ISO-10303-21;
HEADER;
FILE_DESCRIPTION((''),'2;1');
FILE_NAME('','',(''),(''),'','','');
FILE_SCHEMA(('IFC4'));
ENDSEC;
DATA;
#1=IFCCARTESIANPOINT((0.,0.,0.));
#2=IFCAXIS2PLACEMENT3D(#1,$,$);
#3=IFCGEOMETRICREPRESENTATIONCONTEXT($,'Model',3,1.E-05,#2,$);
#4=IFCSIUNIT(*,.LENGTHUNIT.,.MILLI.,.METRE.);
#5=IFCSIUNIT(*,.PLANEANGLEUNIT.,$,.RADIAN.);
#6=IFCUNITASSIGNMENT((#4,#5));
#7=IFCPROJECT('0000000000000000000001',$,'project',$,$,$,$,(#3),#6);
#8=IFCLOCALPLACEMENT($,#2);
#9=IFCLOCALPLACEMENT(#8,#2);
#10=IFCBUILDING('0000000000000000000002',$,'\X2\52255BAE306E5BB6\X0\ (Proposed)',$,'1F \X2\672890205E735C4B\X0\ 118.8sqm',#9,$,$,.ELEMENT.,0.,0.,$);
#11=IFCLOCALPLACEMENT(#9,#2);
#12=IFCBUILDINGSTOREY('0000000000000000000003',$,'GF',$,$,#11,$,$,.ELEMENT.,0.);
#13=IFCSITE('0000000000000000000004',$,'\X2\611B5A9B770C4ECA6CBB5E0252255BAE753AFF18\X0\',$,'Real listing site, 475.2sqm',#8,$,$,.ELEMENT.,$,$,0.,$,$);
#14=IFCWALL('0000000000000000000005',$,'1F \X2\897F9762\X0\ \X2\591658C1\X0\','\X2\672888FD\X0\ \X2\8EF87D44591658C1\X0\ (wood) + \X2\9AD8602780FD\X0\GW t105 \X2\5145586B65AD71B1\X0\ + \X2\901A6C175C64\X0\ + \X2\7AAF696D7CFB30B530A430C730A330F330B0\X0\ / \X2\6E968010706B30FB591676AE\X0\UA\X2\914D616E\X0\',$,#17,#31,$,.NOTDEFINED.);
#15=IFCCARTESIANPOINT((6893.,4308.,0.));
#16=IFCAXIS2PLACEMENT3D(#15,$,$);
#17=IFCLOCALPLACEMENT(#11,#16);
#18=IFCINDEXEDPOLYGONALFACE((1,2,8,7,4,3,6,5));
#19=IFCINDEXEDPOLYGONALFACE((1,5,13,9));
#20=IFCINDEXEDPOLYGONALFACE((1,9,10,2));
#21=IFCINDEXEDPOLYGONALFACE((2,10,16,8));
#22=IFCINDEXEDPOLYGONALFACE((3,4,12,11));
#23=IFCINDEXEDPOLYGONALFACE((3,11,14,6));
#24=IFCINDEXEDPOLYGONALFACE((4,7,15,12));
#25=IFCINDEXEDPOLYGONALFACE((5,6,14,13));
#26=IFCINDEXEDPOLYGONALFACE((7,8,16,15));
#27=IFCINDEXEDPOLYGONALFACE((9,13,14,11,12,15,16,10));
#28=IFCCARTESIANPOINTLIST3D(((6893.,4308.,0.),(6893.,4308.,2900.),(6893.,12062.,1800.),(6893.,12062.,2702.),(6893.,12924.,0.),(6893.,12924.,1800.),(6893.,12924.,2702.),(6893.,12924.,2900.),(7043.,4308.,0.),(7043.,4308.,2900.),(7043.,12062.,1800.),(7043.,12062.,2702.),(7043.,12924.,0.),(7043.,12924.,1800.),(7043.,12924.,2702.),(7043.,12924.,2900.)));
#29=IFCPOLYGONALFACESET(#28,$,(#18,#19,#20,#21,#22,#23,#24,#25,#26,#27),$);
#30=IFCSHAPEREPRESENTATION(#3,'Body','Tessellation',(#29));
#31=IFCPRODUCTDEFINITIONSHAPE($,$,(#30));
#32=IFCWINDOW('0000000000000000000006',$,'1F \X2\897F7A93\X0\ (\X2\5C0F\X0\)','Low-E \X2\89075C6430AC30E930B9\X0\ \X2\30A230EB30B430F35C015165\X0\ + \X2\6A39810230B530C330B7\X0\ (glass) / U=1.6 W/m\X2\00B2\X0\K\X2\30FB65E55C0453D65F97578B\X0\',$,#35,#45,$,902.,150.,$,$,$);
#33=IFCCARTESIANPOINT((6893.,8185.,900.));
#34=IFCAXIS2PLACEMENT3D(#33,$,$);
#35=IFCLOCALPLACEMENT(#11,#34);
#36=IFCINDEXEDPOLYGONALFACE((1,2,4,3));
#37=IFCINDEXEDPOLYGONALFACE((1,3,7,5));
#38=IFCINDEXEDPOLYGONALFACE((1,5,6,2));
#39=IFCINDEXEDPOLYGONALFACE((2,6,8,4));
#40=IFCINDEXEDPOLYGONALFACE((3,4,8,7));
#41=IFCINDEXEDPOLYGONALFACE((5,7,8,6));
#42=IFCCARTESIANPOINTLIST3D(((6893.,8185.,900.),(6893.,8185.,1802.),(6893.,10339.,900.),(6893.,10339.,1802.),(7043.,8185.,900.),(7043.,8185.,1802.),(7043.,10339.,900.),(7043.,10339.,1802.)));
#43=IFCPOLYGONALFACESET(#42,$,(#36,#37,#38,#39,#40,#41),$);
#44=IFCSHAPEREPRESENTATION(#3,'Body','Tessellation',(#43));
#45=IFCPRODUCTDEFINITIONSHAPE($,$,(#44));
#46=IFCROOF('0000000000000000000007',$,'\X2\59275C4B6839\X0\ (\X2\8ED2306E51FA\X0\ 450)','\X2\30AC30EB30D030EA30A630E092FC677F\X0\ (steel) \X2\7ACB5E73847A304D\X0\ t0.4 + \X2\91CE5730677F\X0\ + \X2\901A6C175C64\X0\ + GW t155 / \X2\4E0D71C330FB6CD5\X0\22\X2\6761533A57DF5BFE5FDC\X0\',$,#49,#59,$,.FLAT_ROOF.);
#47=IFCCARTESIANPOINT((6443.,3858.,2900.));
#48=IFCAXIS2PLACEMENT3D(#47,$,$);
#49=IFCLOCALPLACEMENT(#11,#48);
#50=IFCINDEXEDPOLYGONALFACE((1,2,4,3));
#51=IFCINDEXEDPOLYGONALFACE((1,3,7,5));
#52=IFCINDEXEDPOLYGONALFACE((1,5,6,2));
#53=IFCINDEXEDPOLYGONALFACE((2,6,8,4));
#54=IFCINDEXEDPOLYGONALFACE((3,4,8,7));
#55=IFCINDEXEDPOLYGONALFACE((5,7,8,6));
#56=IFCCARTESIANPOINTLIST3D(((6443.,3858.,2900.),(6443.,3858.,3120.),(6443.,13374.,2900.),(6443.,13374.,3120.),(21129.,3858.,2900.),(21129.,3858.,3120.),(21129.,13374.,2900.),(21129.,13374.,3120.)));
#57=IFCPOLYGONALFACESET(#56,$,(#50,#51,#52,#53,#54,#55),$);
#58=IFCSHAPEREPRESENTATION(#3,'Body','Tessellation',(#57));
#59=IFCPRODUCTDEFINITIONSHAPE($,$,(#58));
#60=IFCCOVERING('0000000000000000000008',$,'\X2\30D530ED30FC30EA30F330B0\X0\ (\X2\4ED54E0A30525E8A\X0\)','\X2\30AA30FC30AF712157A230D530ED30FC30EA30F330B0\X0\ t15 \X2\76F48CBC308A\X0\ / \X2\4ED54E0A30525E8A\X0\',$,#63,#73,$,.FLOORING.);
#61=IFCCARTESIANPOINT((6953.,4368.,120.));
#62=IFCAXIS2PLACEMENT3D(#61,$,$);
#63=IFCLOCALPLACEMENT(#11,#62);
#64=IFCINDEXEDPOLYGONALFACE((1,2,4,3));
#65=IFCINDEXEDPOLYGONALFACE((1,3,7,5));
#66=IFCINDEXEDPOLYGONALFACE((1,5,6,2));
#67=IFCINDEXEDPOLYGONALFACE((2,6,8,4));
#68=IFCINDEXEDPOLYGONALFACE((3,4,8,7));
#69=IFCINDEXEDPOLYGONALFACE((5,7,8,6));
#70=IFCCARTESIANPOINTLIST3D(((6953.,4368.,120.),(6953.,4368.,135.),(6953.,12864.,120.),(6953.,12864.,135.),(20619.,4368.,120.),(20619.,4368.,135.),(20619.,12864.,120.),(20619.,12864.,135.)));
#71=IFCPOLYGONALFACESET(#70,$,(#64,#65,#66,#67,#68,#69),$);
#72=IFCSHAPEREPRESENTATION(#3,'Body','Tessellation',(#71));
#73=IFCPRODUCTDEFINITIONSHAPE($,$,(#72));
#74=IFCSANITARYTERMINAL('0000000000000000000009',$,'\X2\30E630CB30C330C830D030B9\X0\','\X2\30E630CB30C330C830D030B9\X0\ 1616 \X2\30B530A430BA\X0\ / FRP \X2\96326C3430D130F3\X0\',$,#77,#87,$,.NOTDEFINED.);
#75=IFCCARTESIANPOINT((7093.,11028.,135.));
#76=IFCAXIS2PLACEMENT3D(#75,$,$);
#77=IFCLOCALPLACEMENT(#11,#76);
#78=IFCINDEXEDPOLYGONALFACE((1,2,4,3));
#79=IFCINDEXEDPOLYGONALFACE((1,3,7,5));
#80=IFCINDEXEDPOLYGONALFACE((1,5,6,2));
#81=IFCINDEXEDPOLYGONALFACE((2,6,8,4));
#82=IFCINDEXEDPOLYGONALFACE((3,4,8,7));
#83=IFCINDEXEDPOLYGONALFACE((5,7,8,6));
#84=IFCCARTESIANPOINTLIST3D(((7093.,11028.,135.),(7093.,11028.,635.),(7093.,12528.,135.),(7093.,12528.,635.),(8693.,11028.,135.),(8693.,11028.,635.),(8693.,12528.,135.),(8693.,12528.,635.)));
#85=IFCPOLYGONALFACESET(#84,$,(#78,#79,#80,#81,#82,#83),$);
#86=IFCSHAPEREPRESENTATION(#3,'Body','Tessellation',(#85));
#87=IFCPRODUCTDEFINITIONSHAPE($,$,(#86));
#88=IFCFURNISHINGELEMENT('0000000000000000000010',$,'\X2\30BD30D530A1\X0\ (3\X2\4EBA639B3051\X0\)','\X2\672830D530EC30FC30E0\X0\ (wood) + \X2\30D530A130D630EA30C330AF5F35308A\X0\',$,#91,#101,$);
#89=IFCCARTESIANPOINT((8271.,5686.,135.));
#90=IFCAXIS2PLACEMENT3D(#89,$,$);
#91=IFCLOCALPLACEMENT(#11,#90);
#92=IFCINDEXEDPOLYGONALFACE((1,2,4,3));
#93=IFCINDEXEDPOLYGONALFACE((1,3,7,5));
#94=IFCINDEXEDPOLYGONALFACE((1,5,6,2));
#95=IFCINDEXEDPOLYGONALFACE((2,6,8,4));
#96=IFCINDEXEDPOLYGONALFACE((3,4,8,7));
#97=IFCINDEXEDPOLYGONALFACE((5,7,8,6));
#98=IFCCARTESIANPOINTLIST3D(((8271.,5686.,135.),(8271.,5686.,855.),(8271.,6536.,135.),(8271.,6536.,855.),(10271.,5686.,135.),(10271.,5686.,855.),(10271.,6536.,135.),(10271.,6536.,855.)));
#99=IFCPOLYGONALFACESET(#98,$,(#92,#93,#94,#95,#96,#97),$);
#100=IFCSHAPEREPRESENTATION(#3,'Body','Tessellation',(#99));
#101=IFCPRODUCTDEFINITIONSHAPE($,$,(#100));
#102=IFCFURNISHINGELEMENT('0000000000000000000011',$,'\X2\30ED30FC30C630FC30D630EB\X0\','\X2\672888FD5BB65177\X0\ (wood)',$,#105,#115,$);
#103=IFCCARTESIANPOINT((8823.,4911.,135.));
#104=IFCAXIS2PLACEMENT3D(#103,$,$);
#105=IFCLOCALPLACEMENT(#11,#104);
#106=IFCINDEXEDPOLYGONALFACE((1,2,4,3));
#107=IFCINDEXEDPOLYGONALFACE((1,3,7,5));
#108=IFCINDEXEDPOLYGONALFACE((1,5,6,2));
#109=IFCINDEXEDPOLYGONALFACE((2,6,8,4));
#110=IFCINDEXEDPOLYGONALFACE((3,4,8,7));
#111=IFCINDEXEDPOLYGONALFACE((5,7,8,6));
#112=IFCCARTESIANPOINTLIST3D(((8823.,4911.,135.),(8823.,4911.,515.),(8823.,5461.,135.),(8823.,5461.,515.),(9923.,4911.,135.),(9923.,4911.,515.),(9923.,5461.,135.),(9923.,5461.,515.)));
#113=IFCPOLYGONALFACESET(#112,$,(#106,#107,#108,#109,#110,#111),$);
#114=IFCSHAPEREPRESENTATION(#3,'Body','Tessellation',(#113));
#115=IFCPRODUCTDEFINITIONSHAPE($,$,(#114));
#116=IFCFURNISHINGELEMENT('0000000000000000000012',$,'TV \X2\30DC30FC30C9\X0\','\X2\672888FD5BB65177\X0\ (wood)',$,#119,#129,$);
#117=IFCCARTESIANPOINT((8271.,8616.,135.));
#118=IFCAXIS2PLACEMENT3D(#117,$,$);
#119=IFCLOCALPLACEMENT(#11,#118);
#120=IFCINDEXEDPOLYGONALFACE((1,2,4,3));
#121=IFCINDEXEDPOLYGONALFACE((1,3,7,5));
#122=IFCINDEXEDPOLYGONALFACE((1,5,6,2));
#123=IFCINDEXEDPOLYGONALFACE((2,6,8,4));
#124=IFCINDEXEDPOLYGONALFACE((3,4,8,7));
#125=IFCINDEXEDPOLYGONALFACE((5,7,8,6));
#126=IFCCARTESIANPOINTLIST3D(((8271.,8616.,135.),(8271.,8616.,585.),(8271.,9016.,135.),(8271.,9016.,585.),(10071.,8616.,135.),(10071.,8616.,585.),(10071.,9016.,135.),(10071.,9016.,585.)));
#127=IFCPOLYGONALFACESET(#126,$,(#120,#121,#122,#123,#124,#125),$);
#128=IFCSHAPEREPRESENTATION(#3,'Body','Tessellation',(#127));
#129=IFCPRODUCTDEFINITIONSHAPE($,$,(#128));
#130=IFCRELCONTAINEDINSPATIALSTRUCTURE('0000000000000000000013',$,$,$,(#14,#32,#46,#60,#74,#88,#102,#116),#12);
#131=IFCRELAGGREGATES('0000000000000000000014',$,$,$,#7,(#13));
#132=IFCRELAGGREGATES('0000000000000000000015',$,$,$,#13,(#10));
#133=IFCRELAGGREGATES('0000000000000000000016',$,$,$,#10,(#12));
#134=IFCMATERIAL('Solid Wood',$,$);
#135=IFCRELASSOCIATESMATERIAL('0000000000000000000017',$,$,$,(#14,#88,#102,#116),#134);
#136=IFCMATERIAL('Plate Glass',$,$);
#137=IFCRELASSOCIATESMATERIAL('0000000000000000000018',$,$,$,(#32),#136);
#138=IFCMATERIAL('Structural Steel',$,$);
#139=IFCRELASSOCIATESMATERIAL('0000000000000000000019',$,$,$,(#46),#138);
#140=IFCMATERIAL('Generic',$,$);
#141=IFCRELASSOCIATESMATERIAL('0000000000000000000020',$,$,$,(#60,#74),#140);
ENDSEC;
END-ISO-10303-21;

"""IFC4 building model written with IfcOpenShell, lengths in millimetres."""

from ifc_helpers import new_model, si_unit, frame, frame_2d, origin, place, context, project, spatial, rectangle, extrude, material, element, fill, save


model = new_model("IFC4")

# Units and contexts
model_context = context("Model", 3, precision=1e-05, world=origin())
ifc_project = project(units=[si_unit("LENGTHUNIT", "METRE", prefix="MILLI"), si_unit("PLANEANGLEUNIT", "RADIAN")], contexts=[model_context])

# Site, building, storey
site_placement = place(None, origin())
site = spatial("IfcSite", under=ifc_project, at=site_placement, Name="愛媛県今治市別宮町８", ObjectType="Real listing site, 475.2sqm", CompositionType="ELEMENT", RefElevation=0.0)
building_placement = place(site_placement, origin())
building = spatial("IfcBuilding", under=site, at=building_placement, Name="別宮の家 (Proposed)", ObjectType="1F 木造平屋 118.8sqm", CompositionType="ELEMENT", ElevationOfRefHeight=0.0, ElevationOfTerrain=0.0)
storey_placement = place(building_placement, origin())
storey = spatial("IfcBuildingStorey", under=building, at=storey_placement, Name="GF", CompositionType="ELEMENT", Elevation=0.0)

# Shared definitions
ifc_material_1 = material(Name="Solid Wood")

# Shared definitions
ifc_material_2 = material(Name="Plate Glass")

# Wall, opening, window
wall_1_placement = place(storey_placement, frame((6893.0, 4308.0, 0.0)))
wall_1 = element("IfcWall", 1, at=wall_1_placement, inside=storey, material=ifc_material_1, Name="1F 西面 外壁", Description="木製 軸組外壁 (wood) + 高性能GW t105 充填断熱 + 通気層 + 窯業系サイディング / 準耐火・外皮UA配慮", PredefinedType="NOTDEFINED", context=model_context, shape_type="SweptSolid", body=[
    extrude(rectangle(XDim=150.0, YDim=8616.0, at=frame_2d((75.0, 4308.0))), frame((6893.0, 4308.0, 0.0)), (0.0, 0.0, 1.0), 2900.0),
])
opening_1_placement = place(storey_placement, frame((6893.0, 8185.0, 900.0)))
opening_1 = element("IfcOpeningElement", 2, at=opening_1_placement, cuts=wall_1, PredefinedType="NOTDEFINED", context=model_context, shape_type="SweptSolid", body=[
    extrude(rectangle(XDim=150.0, YDim=2154.0, at=frame_2d((75.0, 1077.0))), frame((6893.0, 8185.0, 900.0)), (0.0, 0.0, 1.0), 902.0),
])
window_1_placement = place(storey_placement, frame((6893.0, 8185.0, 900.0)))
window_1 = element("IfcWindow", 3, at=window_1_placement, inside=storey, material=ifc_material_2, Name="1F 西窓 (小)", Description="Low-E 複層ガラス アルゴン封入 + 樹脂サッシ (glass) / U=1.6 W/m²K・日射取得型", OverallHeight=902.0, OverallWidth=150.0, context=model_context, shape_type="SweptSolid", body=[
    extrude(rectangle(XDim=150.0, YDim=2154.0, at=frame_2d((75.0, 1077.0))), frame((6893.0, 8185.0, 900.0)), (0.0, 0.0, 1.0), 902.0),
])
fill(opening_1, window_1)

# Roof
ifc_material_3 = material(Name="Structural Steel")
roof_placement = place(storey_placement, frame((6443.0, 3858.0, 2900.0)))
element("IfcRoof", 4, at=roof_placement, inside=storey, material=ifc_material_3, Name="大屋根 (軒の出 450)", Description="ガルバリウム鋼板 (steel) 立平葺き t0.4 + 野地板 + 通気層 + GW t155 / 不燃・法22条区域対応", PredefinedType="FLAT_ROOF", context=model_context, shape_type="SweptSolid", body=[
    extrude(rectangle(XDim=14686.0, YDim=9516.0, at=frame_2d((7343.0, 4758.0))), frame((6443.0, 3858.0, 2900.0)), (0.0, 0.0, 1.0), 220.0),
])

# Covering
ifc_material_4 = material(Name="Generic")
covering_placement = place(storey_placement, frame((6953.0, 4368.0, 120.0)))
element("IfcCovering", 5, at=covering_placement, inside=storey, material=ifc_material_4, Name="フローリング (仕上げ床)", Description="オーク無垢フローリング t15 直貼り / 仕上げ床", PredefinedType="FLOORING", context=model_context, shape_type="SweptSolid", body=[
    extrude(rectangle(XDim=13666.0, YDim=8496.0, at=frame_2d((6833.0, 4248.0))), frame((6953.0, 4368.0, 120.0)), (0.0, 0.0, 1.0), 15.0),
])

# Sanitary terminal
sanitary_terminal_placement = place(storey_placement, frame((7093.0, 11028.0, 135.0)))
element("IfcSanitaryTerminal", 6, at=sanitary_terminal_placement, inside=storey, material=ifc_material_4, Name="ユニットバス", Description="ユニットバス 1616 サイズ / FRP 防水パン", PredefinedType="NOTDEFINED", context=model_context, shape_type="SweptSolid", body=[
    extrude(rectangle(XDim=1600.0, YDim=1500.0, at=frame_2d((800.0, 750.0))), frame((7093.0, 11028.0, 135.0)), (0.0, 0.0, 1.0), 500.0),
])

# Furnishing elements
furnishing_1_placement = place(storey_placement, frame((8271.0, 5686.0, 135.0)))
element("IfcFurnishingElement", 7, at=furnishing_1_placement, inside=storey, material=ifc_material_1, Name="ソファ (3人掛け)", Description="木フレーム (wood) + ファブリック張り", context=model_context, shape_type="SweptSolid", body=[
    extrude(rectangle(XDim=2000.0, YDim=850.0, at=frame_2d((1000.0, 425.0))), frame((8271.0, 5686.0, 135.0)), (0.0, 0.0, 1.0), 720.0),
])
furnishing_2_placement = place(storey_placement, frame((8823.0, 4911.0, 135.0)))
element("IfcFurnishingElement", 8, at=furnishing_2_placement, inside=storey, material=ifc_material_1, Name="ローテーブル", Description="木製家具 (wood)", context=model_context, shape_type="SweptSolid", body=[
    extrude(rectangle(XDim=1100.0, YDim=550.0, at=frame_2d((550.0, 275.0))), frame((8823.0, 4911.0, 135.0)), (0.0, 0.0, 1.0), 380.0),
])
furnishing_3_placement = place(storey_placement, frame((8271.0, 8616.0, 135.0)))
element("IfcFurnishingElement", 9, at=furnishing_3_placement, inside=storey, material=ifc_material_1, Name="TV ボード", Description="木製家具 (wood)", context=model_context, shape_type="SweptSolid", body=[
    extrude(rectangle(XDim=1800.0, YDim=400.0, at=frame_2d((900.0, 200.0))), frame((8271.0, 8616.0, 135.0)), (0.0, 0.0, 1.0), 450.0),
])

save(model, "model.ifc")
